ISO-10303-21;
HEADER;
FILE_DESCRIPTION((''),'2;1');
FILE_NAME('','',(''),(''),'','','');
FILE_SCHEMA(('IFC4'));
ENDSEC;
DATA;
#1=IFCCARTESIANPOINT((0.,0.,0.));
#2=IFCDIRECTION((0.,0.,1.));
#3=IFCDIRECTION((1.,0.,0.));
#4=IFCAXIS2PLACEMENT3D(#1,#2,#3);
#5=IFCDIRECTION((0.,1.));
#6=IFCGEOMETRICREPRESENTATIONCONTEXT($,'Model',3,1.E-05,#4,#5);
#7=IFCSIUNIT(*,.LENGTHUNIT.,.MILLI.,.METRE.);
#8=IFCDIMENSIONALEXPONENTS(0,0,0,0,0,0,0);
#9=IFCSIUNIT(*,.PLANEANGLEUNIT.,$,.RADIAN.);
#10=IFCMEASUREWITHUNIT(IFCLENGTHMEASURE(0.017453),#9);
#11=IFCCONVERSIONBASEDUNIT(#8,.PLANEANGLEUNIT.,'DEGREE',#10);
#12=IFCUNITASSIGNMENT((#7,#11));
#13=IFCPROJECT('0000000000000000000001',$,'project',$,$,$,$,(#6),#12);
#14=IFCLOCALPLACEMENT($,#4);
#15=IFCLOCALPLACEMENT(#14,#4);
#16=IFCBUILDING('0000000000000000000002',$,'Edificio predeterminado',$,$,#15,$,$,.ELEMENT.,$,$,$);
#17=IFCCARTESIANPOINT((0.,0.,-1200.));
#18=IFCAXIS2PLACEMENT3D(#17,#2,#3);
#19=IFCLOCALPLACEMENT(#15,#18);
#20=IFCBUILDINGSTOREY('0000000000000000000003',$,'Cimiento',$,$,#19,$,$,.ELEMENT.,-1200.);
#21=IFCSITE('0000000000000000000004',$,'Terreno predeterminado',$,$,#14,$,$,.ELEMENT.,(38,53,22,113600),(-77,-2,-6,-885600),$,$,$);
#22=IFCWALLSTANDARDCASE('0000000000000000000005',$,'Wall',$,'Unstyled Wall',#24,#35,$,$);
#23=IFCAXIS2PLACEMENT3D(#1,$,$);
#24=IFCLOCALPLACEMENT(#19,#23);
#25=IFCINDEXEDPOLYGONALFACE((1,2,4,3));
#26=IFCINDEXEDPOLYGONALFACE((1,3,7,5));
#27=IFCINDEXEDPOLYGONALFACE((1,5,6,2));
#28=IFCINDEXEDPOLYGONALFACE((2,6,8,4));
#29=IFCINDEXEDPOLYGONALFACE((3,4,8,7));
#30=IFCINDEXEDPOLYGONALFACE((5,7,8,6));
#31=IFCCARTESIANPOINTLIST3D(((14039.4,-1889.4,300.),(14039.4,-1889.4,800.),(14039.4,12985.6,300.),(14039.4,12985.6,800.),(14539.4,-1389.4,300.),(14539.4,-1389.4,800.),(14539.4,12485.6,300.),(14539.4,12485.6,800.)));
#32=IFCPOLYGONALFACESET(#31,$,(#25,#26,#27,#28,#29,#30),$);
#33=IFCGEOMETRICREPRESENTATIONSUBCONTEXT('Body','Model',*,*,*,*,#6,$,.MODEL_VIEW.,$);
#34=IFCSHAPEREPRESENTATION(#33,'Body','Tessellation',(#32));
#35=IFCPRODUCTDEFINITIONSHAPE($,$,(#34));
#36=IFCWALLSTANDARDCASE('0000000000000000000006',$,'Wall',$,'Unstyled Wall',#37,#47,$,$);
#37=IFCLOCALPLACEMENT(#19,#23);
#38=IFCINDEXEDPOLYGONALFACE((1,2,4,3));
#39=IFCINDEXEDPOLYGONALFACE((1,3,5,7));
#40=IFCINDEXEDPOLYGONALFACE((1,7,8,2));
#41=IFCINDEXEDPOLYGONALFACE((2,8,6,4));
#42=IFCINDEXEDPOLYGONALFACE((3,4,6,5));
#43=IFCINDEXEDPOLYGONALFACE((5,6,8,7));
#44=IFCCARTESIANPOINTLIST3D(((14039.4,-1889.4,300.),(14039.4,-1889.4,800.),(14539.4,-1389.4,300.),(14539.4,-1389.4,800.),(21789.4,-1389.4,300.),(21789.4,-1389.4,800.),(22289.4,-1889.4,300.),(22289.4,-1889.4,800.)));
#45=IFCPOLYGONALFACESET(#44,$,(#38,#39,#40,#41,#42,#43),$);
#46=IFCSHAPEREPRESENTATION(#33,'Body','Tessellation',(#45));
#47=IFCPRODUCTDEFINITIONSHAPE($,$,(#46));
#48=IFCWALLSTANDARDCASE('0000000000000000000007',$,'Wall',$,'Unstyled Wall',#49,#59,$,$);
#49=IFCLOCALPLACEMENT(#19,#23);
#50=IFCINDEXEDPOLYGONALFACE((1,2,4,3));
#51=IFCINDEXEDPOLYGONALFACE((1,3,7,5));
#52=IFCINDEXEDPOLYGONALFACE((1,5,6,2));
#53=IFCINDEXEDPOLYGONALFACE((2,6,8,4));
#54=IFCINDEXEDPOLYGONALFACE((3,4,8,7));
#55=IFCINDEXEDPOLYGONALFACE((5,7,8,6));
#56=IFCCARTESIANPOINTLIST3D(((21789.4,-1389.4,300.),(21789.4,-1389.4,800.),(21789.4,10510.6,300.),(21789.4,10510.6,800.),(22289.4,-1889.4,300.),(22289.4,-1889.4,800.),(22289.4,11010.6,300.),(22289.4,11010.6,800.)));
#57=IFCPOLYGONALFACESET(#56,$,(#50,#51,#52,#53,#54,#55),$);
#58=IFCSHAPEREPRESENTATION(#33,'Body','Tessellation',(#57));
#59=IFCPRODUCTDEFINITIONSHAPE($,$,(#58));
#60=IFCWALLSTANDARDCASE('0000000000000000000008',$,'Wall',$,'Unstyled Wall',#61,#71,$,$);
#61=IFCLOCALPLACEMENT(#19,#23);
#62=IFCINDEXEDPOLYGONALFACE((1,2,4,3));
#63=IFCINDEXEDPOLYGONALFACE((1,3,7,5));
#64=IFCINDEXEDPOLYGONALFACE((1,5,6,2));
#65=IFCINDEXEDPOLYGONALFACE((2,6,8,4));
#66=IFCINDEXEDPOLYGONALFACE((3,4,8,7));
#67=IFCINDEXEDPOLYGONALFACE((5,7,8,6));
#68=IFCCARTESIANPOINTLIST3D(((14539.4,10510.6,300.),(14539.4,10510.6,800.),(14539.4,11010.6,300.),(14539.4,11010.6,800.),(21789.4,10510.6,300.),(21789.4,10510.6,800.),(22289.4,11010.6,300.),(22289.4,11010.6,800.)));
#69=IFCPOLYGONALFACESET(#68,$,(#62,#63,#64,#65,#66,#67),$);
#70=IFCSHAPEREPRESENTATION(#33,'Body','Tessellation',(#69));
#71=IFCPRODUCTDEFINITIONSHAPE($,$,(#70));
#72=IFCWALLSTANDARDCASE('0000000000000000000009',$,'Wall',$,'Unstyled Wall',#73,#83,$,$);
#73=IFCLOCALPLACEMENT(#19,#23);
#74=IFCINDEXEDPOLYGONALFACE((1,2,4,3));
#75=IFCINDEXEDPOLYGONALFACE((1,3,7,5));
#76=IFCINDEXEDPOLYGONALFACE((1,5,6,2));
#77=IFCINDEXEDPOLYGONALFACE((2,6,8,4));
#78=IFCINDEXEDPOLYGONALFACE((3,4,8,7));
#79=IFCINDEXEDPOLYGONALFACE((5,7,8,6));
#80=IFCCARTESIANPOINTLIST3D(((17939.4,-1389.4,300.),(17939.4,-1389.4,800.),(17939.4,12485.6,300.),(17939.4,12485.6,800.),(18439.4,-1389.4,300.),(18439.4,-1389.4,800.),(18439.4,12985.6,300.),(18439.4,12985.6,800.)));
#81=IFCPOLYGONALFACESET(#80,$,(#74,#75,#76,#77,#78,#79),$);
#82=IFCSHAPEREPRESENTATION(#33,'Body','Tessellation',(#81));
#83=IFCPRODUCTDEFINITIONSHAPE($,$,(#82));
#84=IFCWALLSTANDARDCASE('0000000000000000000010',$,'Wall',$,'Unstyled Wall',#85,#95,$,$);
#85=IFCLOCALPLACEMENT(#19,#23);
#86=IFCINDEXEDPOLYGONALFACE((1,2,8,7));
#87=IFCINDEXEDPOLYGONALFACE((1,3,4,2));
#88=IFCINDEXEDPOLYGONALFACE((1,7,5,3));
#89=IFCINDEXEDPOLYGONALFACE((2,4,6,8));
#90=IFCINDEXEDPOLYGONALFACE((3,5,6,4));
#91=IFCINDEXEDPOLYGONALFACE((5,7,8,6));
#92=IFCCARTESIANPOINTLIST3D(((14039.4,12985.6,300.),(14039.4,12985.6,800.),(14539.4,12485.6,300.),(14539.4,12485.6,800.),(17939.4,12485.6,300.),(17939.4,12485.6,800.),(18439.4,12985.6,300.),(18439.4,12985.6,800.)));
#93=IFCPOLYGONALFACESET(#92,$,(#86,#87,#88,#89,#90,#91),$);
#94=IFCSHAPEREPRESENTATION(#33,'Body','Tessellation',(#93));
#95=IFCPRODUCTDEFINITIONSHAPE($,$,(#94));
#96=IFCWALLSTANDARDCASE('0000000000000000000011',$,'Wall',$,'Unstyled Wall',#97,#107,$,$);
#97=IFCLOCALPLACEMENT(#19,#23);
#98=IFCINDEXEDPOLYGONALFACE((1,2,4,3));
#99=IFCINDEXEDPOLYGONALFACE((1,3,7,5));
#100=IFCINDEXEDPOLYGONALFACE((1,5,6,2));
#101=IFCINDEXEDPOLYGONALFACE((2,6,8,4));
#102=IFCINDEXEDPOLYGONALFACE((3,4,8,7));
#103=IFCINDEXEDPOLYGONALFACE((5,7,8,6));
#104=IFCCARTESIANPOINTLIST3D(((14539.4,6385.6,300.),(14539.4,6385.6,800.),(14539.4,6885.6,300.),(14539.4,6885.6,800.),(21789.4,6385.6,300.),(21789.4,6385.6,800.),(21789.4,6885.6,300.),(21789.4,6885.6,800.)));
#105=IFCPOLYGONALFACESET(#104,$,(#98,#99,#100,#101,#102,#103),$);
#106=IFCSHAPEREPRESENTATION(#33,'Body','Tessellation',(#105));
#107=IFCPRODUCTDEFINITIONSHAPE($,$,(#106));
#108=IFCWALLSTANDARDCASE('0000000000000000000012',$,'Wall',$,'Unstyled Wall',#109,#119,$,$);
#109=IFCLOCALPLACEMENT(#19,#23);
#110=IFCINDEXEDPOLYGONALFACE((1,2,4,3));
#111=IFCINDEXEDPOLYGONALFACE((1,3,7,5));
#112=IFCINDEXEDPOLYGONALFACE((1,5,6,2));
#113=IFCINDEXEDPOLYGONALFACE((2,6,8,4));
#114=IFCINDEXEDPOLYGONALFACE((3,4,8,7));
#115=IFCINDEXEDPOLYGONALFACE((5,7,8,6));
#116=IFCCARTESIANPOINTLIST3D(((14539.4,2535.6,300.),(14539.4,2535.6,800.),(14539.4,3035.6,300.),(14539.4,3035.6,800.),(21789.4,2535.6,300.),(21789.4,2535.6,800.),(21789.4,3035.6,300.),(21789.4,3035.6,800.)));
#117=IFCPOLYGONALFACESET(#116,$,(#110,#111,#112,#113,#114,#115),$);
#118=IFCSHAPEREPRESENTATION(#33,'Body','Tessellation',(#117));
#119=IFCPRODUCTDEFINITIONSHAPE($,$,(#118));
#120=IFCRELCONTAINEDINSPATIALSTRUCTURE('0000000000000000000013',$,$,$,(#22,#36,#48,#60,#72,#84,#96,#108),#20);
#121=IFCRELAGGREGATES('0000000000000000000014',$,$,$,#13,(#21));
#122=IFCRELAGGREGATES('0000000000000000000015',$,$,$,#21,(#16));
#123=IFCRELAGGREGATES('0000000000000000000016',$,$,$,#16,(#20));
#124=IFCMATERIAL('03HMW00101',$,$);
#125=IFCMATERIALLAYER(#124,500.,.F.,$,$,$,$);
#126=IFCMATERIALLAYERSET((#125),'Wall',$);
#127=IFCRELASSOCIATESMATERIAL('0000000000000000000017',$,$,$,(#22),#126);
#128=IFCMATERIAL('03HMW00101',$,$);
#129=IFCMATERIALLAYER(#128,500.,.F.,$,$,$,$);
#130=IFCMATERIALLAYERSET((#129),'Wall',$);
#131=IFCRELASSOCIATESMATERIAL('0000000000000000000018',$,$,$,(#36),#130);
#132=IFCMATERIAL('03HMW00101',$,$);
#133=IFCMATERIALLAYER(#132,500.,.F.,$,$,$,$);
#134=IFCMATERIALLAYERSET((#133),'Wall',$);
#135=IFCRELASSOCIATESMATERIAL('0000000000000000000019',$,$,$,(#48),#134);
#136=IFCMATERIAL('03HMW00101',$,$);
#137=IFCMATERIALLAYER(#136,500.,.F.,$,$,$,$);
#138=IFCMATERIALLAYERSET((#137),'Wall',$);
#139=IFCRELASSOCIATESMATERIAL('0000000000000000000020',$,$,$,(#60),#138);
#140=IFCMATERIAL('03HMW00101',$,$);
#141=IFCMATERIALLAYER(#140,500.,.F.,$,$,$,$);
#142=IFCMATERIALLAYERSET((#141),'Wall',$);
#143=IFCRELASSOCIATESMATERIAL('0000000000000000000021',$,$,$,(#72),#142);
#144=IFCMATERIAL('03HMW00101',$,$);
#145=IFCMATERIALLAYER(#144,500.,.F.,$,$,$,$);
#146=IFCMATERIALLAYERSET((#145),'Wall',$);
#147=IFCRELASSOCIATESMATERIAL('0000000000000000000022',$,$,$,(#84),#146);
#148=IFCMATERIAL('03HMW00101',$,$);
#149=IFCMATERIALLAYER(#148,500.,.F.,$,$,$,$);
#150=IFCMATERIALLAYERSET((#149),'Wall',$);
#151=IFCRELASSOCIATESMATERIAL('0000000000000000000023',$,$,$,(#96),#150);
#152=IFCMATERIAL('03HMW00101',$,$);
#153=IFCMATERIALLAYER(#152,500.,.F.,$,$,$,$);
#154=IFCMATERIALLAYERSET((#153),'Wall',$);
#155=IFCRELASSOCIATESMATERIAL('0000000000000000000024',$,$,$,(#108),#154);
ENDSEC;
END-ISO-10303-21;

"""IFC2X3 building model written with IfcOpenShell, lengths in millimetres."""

from ifc_helpers import new_model, entity, si_unit, converted_unit, direction, frame, origin_with_axes, place, context, subcontext, project, spatial, polyline, outline, extrude, material, layer, layer_set, layer_usage, element, save


model = new_model("IFC2X3")

# Units and contexts
model_context = context("Model", 3, precision=1e-05, world=origin_with_axes(), true_north=direction((0.0, 1.0)))
body_context = subcontext(model_context, "Body", "Model", "MODEL_VIEW")
ifc_project = project(units=[si_unit("LENGTHUNIT", "METRE", prefix="MILLI"), converted_unit("PLANEANGLEUNIT", "DEGREE", entity("IfcLengthMeasure", 0.017453), si_unit("PLANEANGLEUNIT", "RADIAN"), dimensions=[0, 0, 0, 0, 0, 0, 0])], contexts=[model_context])

# Site, building, storey
site_placement = place(None, origin_with_axes())
site = spatial("IfcSite", under=ifc_project, at=site_placement, Name="Terreno predeterminado", CompositionType="ELEMENT", RefLatitude=(38, 53, 22, 113600), RefLongitude=(-77, -2, -6, -885600))
building_placement = place(site_placement, origin_with_axes())
building = spatial("IfcBuilding", under=site, at=building_placement, Name="Edificio predeterminado", CompositionType="ELEMENT")
storey_placement = place(building_placement, frame((0.0, 0.0, -1200.0), z_axis=(0.0, 0.0, 1.0), x_axis=(1.0, 0.0, 0.0)))
storey = spatial("IfcBuildingStorey", under=building, at=storey_placement, Name="Cimiento", CompositionType="ELEMENT", Elevation=-1200.0)

# Walls
ifc_material_1 = material(Name="03HMW00101")
ifc_layer_1 = layer(ifc_material_1, 500.0, ventilated=False)
ifc_layer_set_1 = layer_set([ifc_layer_1], Name="Wall")
ifc_layer_usage_1 = layer_usage(ifc_layer_set_1, "AXIS2", "POSITIVE", -250.0)
wall_1_placement = place(storey_placement, frame((14289.4, 12735.6, 300.0), z_axis=(0.0, 0.0, 1.0), x_axis=(0.0, -1.0, 0.0)))
element("IfcWallStandardCase", 1, at=wall_1_placement, inside=storey, material=ifc_layer_usage_1, Name="Wall", ObjectType="Unstyled Wall", context=body_context, shape_type="SweptSolid", body=[
    extrude(outline(polyline([(250.0, 250.0), (-250.0, -250.0), (14625.0, -250.0), (14125.0, 250.0), (250.0, 250.0)])), origin_with_axes(), (0.0, 0.0, 1.0), 500.0),
])
ifc_material_2 = material(Name="03HMW00101")
ifc_layer_2 = layer(ifc_material_2, 500.0, ventilated=False)
ifc_layer_set_2 = layer_set([ifc_layer_2], Name="Wall")
ifc_layer_usage_2 = layer_usage(ifc_layer_set_2, "AXIS2", "POSITIVE", -250.0)
wall_2_placement = place(storey_placement, frame((14289.4, -1639.4, 300.0), z_axis=(0.0, 0.0, 1.0), x_axis=(1.0, 0.0, 0.0)))
element("IfcWallStandardCase", 2, at=wall_2_placement, inside=storey, material=ifc_layer_usage_2, Name="Wall", ObjectType="Unstyled Wall", context=body_context, shape_type="SweptSolid", body=[
    extrude(outline(polyline([(-250.0, -250.0), (250.0, 250.0), (7500.0, 250.0), (8000.0, -250.0), (-250.0, -250.0)])), origin_with_axes(), (0.0, 0.0, 1.0), 500.0),
])
ifc_material_3 = material(Name="03HMW00101")
ifc_layer_3 = layer(ifc_material_3, 500.0, ventilated=False)
ifc_layer_set_3 = layer_set([ifc_layer_3], Name="Wall")
ifc_layer_usage_3 = layer_usage(ifc_layer_set_3, "AXIS2", "POSITIVE", -250.0)
wall_3_placement = place(storey_placement, frame((22039.4, -1639.4, 300.0), z_axis=(0.0, 0.0, 1.0), x_axis=(0.0, 1.0, 0.0)))
element("IfcWallStandardCase", 3, at=wall_3_placement, inside=storey, material=ifc_layer_usage_3, Name="Wall", ObjectType="Unstyled Wall", context=body_context, shape_type="SweptSolid", body=[
    extrude(outline(polyline([(-250.0, -250.0), (250.0, 250.0), (12150.0, 250.0), (12650.0, -250.0), (-250.0, -250.0)])), origin_with_axes(), (0.0, 0.0, 1.0), 500.0),
])
ifc_material_4 = material(Name="03HMW00101")
ifc_layer_4 = layer(ifc_material_4, 500.0, ventilated=False)
ifc_layer_set_4 = layer_set([ifc_layer_4], Name="Wall")
ifc_layer_usage_4 = layer_usage(ifc_layer_set_4, "AXIS2", "POSITIVE", -250.0)
wall_4_placement = place(storey_placement, frame((22039.4, 10760.6, 300.0), z_axis=(0.0, 0.0, 1.0), x_axis=(-1.0, 0.0, 0.0)))
element("IfcWallStandardCase", 4, at=wall_4_placement, inside=storey, material=ifc_layer_usage_4, Name="Wall", ObjectType="Unstyled Wall", context=body_context, shape_type="SweptSolid", body=[
    extrude(outline(polyline([(-250.0, -250.0), (250.0, 250.0), (7500.0, 250.0), (7500.0, -250.0), (-250.0, -250.0)])), origin_with_axes(), (0.0, 0.0, 1.0), 500.0),
])
ifc_material_5 = material(Name="03HMW00101")
ifc_layer_5 = layer(ifc_material_5, 500.0, ventilated=False)
ifc_layer_set_5 = layer_set([ifc_layer_5], Name="Wall")
ifc_layer_usage_5 = layer_usage(ifc_layer_set_5, "AXIS2", "POSITIVE", -250.0)
wall_5_placement = place(storey_placement, frame((18189.4, -1639.4, 300.0), z_axis=(0.0, 0.0, 1.0), x_axis=(0.0, 1.0, 0.0)))
element("IfcWallStandardCase", 5, at=wall_5_placement, inside=storey, material=ifc_layer_usage_5, Name="Wall", ObjectType="Unstyled Wall", context=body_context, shape_type="SweptSolid", body=[
    extrude(outline(polyline([(250.0, 250.0), (250.0, -250.0), (14625.0, -250.0), (14125.0, 250.0), (250.0, 250.0)])), origin_with_axes(), (0.0, 0.0, 1.0), 500.0),
])
ifc_material_6 = material(Name="03HMW00101")
ifc_layer_6 = layer(ifc_material_6, 500.0, ventilated=False)
ifc_layer_set_6 = layer_set([ifc_layer_6], Name="Wall")
ifc_layer_usage_6 = layer_usage(ifc_layer_set_6, "AXIS2", "POSITIVE", -250.0)
wall_6_placement = place(storey_placement, frame((18189.4, 12735.6, 300.0), z_axis=(0.0, 0.0, 1.0), x_axis=(-1.0, 0.0, 0.0)))
element("IfcWallStandardCase", 6, at=wall_6_placement, inside=storey, material=ifc_layer_usage_6, Name="Wall", ObjectType="Unstyled Wall", context=body_context, shape_type="SweptSolid", body=[
    extrude(outline(polyline([(-250.0, -250.0), (250.0, 250.0), (3650.0, 250.0), (4150.0, -250.0), (-250.0, -250.0)])), origin_with_axes(), (0.0, 0.0, 1.0), 500.0),
])
ifc_material_7 = material(Name="03HMW00101")
ifc_layer_7 = layer(ifc_material_7, 500.0, ventilated=False)
ifc_layer_set_7 = layer_set([ifc_layer_7], Name="Wall")
ifc_layer_usage_7 = layer_usage(ifc_layer_set_7, "AXIS2", "POSITIVE", -250.0)
wall_7_placement = place(storey_placement, frame((14289.4, 6635.6, 300.0), z_axis=(0.0, 0.0, 1.0), x_axis=(1.0, 0.0, 0.0)))
element("IfcWallStandardCase", 7, at=wall_7_placement, inside=storey, material=ifc_layer_usage_7, Name="Wall", ObjectType="Unstyled Wall", context=body_context, shape_type="SweptSolid", body=[
    extrude(outline(polyline([(250.0, -250.0), (250.0, 250.0), (7500.0, 250.0), (7500.0, -250.0), (250.0, -250.0)])), origin_with_axes(), (0.0, 0.0, 1.0), 500.0),
])
ifc_material_8 = material(Name="03HMW00101")
ifc_layer_8 = layer(ifc_material_8, 500.0, ventilated=False)
ifc_layer_set_8 = layer_set([ifc_layer_8], Name="Wall")
ifc_layer_usage_8 = layer_usage(ifc_layer_set_8, "AXIS2", "POSITIVE", -250.0)
wall_8_placement = place(storey_placement, frame((14289.4, 2785.6, 300.0), z_axis=(0.0, 0.0, 1.0), x_axis=(1.0, 0.0, 0.0)))
element("IfcWallStandardCase", 8, at=wall_8_placement, inside=storey, material=ifc_layer_usage_8, Name="Wall", ObjectType="Unstyled Wall", context=body_context, shape_type="SweptSolid", body=[
    extrude(outline(polyline([(250.0, -250.0), (250.0, 250.0), (7500.0, 250.0), (7500.0, -250.0), (250.0, -250.0)])), origin_with_axes(), (0.0, 0.0, 1.0), 500.0),
])

save(model, "model.ifc")
